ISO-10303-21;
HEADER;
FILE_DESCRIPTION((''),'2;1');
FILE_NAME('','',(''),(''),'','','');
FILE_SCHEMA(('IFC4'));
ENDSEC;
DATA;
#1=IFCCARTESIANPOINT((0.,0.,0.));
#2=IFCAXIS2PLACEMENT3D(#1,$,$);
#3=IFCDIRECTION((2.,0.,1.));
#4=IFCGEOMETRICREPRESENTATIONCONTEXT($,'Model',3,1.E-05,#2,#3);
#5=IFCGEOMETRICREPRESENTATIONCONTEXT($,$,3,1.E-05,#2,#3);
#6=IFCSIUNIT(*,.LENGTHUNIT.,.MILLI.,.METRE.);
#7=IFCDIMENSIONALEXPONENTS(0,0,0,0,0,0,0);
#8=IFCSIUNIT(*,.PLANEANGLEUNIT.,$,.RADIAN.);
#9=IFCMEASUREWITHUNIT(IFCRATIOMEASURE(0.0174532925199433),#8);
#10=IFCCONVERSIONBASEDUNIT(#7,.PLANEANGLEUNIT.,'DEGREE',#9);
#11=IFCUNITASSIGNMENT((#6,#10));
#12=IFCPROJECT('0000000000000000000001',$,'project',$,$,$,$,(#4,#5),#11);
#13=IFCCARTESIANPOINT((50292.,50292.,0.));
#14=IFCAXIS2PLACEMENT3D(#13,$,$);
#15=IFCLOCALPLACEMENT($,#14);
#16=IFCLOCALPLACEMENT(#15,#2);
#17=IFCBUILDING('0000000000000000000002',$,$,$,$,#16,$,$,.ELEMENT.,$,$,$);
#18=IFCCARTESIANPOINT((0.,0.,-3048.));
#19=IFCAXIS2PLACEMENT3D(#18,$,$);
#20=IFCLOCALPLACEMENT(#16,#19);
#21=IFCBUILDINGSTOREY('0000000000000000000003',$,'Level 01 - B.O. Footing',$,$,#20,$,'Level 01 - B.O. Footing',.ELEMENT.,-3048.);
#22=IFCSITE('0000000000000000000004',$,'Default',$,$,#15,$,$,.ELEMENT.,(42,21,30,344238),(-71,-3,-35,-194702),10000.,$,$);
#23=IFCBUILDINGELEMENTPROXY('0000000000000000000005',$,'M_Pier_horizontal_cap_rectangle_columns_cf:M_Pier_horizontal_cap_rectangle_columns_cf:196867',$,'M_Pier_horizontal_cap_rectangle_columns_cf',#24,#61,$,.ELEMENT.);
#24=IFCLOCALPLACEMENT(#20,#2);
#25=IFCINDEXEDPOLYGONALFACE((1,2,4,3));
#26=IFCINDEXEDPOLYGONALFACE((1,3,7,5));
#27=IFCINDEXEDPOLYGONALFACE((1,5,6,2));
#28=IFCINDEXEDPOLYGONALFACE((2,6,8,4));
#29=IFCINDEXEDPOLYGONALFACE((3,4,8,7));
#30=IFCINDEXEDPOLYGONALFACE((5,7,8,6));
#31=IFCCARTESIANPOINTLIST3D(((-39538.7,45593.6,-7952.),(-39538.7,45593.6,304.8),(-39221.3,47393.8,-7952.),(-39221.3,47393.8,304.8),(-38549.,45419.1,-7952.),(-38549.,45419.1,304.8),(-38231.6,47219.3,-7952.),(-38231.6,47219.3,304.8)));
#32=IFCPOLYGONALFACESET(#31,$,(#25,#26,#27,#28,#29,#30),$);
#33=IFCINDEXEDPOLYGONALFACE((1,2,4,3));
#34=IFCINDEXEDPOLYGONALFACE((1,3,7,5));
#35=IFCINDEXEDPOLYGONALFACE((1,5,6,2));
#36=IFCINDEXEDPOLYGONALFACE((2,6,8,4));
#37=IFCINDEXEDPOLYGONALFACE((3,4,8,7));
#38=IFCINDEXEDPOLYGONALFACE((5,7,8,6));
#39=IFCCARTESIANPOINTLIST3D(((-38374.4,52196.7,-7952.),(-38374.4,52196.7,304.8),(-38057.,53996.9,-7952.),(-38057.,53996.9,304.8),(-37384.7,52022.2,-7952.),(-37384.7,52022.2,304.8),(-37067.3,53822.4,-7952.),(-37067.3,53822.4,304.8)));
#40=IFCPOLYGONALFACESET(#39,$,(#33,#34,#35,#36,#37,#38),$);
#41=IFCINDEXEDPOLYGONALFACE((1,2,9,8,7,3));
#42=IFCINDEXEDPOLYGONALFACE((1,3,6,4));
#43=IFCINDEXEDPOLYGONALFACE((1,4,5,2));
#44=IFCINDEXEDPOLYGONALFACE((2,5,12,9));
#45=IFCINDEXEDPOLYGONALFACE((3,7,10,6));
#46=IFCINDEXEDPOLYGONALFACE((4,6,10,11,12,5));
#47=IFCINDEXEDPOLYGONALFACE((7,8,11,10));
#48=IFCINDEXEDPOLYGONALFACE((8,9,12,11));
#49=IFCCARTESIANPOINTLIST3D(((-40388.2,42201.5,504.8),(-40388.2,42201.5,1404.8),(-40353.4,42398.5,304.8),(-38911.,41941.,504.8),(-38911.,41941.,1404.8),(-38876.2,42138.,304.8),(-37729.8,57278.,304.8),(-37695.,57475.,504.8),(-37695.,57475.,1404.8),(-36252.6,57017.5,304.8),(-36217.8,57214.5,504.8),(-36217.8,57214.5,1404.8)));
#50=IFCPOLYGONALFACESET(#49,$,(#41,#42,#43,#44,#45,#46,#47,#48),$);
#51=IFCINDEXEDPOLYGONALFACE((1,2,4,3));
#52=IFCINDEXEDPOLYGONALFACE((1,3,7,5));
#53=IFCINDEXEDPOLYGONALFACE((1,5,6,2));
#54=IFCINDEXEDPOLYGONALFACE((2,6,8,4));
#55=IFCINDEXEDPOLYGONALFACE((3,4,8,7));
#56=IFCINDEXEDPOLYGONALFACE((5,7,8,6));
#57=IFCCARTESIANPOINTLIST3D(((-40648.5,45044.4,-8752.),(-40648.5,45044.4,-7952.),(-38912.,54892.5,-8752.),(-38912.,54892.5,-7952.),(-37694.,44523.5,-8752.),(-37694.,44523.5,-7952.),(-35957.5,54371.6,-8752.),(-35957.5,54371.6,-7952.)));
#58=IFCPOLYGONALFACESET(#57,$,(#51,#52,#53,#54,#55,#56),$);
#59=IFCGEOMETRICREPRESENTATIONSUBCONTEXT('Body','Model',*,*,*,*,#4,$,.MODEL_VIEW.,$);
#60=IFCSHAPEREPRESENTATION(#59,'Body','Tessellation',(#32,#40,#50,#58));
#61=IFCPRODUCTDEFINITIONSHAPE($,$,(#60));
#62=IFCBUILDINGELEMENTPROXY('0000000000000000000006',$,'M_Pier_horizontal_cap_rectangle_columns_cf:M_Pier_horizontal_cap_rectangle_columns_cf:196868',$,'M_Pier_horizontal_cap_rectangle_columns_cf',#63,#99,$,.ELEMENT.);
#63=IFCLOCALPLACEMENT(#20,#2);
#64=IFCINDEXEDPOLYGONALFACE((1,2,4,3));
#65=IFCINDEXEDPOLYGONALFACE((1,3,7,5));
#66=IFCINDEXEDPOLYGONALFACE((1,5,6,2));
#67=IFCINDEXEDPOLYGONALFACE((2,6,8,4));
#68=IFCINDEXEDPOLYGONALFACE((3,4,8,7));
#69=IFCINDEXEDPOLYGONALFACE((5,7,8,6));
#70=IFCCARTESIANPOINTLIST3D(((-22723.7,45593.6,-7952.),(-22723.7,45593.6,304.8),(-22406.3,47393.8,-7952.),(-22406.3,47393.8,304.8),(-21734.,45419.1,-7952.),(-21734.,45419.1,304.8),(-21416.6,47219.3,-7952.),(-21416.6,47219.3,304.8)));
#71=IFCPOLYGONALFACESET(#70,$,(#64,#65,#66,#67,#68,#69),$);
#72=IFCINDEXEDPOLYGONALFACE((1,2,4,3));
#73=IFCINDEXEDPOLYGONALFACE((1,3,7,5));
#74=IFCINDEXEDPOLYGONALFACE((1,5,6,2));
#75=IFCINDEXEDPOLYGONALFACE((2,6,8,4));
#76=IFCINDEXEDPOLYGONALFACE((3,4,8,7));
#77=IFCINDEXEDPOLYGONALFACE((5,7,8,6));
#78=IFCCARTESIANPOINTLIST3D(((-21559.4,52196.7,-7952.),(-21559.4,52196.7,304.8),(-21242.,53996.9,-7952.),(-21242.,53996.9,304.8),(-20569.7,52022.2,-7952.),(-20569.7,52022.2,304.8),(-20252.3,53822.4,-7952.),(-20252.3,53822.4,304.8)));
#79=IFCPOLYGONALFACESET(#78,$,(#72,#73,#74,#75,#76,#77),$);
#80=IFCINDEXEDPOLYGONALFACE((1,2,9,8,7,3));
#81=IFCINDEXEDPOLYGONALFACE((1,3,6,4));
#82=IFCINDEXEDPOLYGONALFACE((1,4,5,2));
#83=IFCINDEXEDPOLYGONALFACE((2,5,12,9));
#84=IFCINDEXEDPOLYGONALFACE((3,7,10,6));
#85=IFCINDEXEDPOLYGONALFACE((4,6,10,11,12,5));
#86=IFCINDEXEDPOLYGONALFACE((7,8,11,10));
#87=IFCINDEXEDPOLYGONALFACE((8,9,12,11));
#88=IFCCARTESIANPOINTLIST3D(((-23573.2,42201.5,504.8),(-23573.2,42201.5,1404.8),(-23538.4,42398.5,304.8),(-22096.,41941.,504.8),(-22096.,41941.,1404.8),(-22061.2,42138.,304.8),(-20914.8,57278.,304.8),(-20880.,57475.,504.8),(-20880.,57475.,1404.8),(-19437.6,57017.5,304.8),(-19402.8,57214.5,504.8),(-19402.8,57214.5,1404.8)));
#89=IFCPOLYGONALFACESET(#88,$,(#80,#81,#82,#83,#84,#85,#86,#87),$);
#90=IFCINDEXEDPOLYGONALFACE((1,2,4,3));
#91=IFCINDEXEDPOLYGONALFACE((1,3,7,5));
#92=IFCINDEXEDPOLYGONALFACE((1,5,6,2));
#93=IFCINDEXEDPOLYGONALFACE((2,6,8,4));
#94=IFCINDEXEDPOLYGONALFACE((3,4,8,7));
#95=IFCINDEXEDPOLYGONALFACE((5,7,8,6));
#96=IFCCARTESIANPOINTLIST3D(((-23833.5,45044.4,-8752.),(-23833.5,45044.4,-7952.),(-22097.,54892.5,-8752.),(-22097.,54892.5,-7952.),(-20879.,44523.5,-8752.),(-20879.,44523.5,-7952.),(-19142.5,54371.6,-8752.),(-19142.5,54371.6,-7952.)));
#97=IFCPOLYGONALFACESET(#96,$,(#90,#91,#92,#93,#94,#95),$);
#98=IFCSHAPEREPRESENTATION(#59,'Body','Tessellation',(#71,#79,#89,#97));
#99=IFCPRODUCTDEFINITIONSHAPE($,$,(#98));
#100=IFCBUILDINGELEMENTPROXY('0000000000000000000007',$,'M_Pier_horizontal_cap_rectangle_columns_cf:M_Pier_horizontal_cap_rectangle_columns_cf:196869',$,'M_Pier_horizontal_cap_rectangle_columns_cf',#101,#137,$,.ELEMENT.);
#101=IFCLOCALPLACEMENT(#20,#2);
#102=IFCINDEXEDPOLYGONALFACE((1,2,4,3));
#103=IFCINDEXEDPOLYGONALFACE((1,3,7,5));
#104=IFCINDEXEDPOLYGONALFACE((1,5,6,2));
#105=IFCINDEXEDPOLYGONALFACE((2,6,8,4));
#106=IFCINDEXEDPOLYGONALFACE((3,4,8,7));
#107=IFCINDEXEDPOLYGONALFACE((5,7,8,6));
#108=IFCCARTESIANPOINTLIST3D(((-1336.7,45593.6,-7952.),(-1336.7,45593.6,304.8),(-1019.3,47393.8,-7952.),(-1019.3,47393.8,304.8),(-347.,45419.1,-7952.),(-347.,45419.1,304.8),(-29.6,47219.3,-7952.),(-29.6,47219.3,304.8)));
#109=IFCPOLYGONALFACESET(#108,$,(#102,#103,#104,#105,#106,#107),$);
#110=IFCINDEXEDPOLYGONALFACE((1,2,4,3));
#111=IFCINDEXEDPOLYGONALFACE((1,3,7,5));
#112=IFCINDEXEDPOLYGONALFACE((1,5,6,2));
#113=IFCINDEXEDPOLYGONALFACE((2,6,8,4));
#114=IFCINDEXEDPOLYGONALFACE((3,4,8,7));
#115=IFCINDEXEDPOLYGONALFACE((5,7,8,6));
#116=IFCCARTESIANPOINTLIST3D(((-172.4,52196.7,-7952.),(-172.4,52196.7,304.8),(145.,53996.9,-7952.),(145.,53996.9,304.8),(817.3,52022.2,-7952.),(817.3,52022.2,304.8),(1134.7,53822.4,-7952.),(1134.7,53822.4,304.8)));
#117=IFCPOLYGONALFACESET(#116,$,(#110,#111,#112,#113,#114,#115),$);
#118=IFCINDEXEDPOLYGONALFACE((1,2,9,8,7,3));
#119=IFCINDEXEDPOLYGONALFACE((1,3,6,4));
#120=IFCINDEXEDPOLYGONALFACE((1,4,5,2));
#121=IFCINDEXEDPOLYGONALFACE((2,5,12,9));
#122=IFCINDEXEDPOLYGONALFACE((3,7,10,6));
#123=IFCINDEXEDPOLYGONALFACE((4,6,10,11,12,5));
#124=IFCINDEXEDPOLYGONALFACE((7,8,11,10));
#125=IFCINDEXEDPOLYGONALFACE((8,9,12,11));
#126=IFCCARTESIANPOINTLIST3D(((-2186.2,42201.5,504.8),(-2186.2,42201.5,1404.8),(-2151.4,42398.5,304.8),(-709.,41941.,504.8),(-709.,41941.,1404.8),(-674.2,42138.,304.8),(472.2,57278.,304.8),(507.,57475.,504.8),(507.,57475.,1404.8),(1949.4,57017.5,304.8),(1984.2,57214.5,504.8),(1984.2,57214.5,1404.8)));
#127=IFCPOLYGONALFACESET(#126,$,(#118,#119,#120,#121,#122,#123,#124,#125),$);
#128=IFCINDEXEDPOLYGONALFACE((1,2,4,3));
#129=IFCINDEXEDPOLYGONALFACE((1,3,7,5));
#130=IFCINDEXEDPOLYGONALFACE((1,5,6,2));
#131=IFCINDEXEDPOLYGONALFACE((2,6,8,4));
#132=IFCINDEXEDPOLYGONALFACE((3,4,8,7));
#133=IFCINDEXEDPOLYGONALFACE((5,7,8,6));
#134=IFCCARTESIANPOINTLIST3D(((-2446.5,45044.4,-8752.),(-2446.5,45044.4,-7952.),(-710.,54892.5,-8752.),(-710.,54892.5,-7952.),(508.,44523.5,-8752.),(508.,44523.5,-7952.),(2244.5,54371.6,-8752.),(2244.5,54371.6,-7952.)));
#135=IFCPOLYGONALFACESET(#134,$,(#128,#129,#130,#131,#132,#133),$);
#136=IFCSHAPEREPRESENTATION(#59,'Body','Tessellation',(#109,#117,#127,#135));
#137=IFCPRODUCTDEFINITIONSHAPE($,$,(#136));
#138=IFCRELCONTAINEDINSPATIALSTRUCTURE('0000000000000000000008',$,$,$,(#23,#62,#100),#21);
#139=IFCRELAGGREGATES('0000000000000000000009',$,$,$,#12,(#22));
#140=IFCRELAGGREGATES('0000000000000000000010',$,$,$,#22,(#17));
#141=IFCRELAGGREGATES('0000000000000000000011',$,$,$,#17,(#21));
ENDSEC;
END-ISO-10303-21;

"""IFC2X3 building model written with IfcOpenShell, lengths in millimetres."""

from ifc_helpers import new_model, entity, si_unit, converted_unit, direction, frame, origin, origin_2d_with_axis, place, context, subcontext, project, spatial, polyline, rectangle, outline, extrude, source, transform, mapped, element, save


model = new_model("IFC2X3")

# Units and contexts
model_context = context("Model", 3, precision=1e-05, world=origin(), true_north=direction((2.0, 0.0, 1.0)))
context_of_model = context(None, 3, precision=1e-05, world=origin(), true_north=direction((2.0, 0.0, 1.0)))
body_context = subcontext(model_context, "Body", "Model", "MODEL_VIEW")
ifc_project = project(units=[si_unit("LENGTHUNIT", "METRE", prefix="MILLI"), converted_unit("PLANEANGLEUNIT", "DEGREE", entity("IfcRatioMeasure", 0.0174532925199433), si_unit("PLANEANGLEUNIT", "RADIAN"), dimensions=[0, 0, 0, 0, 0, 0, 0])], contexts=[model_context, context_of_model])

# Site, building, storey
site_placement = place(None, frame((50292.0, 50292.0, 0.0)))
site = spatial("IfcSite", under=ifc_project, at=site_placement, Name="Default", CompositionType="ELEMENT", RefLatitude=(42, 21, 30, 344238), RefLongitude=(-71, -3, -35, -194702), RefElevation=10000.0)
building_placement = place(site_placement, origin())
building = spatial("IfcBuilding", under=site, at=building_placement, CompositionType="ELEMENT")
storey_placement = place(building_placement, frame((0.0, 0.0, -3048.0)))
storey = spatial("IfcBuildingStorey", under=building, at=storey_placement, Name="Level 01 - B.O. Footing", LongName="Level 01 - B.O. Footing", CompositionType="ELEMENT", Elevation=-3048.0)

# Building element proxies
shared_shape = source(origin(), body_context, "Body", "SweptSolid", [
    extrude(rectangle(XDim=1828.0, YDim=1005.0, at=origin_2d_with_axis()), frame((-3352.5, 0.0, -9356.8), z_axis=(0.0, 0.0, 1.0), x_axis=(-1.0, 0.0, 0.0)), (0.0, 0.0, 1.0), 8256.8),
    extrude(rectangle(XDim=1828.0, YDim=1005.0, at=origin_2d_with_axis()), frame((3352.5, 0.0, -9356.8), z_axis=(0.0, 0.0, 1.0), x_axis=(-1.0, 0.0, 0.0)), (0.0, 0.0, 1.0), 8256.8),
    extrude(outline(polyline([(-7754.5, -666.7), (7754.5, -666.7), (7754.5, 233.3), (7554.5, 433.3), (-7554.5, 433.3), (-7754.5, 233.3), (-7754.5, -666.7)])), frame((0.0, -750.0, -666.7), z_axis=(0.0, 1.0, 0.0), x_axis=(1.0, 0.0, 0.0)), (0.0, 0.0, 1.0), 1500.0),
    extrude(rectangle(XDim=3000.0, YDim=10000.0, at=origin_2d_with_axis()), frame((0.0, 0.0, -10156.8), z_axis=(0.0, 0.0, 1.0), x_axis=(0.0, 1.0, 0.0)), (0.0, 0.0, 1.0), 800.0),
])
for number, where, z_axis, x_axis, name in (
    (1, (-38303.0, 49708.0, 1404.8), (0.0, 0.0, 1.0), (0.173648, 0.984808, 0.0), "M_Pier_horizontal_cap_rectangle_columns_cf:M_Pier_horizontal_cap_rectangle_columns_cf:196867"),
    (2, (-21488.0, 49708.0, 1404.8), (0.0, 0.0, 1.0), (0.173648, 0.984808, 0.0), "M_Pier_horizontal_cap_rectangle_columns_cf:M_Pier_horizontal_cap_rectangle_columns_cf:196868"),
    (3, (-101.0, 49708.0, 1404.8), (0.0, 0.0, 1.0), (0.173648, 0.984808, 0.0), "M_Pier_horizontal_cap_rectangle_columns_cf:M_Pier_horizontal_cap_rectangle_columns_cf:196869"),
):
    element("IfcBuildingElementProxy", number, at=place(storey_placement, frame(where, z_axis=z_axis, x_axis=x_axis)), inside=storey, Name=name, ObjectType="M_Pier_horizontal_cap_rectangle_columns_cf", CompositionType="ELEMENT", context=body_context, shape_type="MappedRepresentation", body=[
        mapped(shared_shape, transform((0.0, 0.0, 0.0), scale=1.0)),
    ])

save(model, "model.ifc")
